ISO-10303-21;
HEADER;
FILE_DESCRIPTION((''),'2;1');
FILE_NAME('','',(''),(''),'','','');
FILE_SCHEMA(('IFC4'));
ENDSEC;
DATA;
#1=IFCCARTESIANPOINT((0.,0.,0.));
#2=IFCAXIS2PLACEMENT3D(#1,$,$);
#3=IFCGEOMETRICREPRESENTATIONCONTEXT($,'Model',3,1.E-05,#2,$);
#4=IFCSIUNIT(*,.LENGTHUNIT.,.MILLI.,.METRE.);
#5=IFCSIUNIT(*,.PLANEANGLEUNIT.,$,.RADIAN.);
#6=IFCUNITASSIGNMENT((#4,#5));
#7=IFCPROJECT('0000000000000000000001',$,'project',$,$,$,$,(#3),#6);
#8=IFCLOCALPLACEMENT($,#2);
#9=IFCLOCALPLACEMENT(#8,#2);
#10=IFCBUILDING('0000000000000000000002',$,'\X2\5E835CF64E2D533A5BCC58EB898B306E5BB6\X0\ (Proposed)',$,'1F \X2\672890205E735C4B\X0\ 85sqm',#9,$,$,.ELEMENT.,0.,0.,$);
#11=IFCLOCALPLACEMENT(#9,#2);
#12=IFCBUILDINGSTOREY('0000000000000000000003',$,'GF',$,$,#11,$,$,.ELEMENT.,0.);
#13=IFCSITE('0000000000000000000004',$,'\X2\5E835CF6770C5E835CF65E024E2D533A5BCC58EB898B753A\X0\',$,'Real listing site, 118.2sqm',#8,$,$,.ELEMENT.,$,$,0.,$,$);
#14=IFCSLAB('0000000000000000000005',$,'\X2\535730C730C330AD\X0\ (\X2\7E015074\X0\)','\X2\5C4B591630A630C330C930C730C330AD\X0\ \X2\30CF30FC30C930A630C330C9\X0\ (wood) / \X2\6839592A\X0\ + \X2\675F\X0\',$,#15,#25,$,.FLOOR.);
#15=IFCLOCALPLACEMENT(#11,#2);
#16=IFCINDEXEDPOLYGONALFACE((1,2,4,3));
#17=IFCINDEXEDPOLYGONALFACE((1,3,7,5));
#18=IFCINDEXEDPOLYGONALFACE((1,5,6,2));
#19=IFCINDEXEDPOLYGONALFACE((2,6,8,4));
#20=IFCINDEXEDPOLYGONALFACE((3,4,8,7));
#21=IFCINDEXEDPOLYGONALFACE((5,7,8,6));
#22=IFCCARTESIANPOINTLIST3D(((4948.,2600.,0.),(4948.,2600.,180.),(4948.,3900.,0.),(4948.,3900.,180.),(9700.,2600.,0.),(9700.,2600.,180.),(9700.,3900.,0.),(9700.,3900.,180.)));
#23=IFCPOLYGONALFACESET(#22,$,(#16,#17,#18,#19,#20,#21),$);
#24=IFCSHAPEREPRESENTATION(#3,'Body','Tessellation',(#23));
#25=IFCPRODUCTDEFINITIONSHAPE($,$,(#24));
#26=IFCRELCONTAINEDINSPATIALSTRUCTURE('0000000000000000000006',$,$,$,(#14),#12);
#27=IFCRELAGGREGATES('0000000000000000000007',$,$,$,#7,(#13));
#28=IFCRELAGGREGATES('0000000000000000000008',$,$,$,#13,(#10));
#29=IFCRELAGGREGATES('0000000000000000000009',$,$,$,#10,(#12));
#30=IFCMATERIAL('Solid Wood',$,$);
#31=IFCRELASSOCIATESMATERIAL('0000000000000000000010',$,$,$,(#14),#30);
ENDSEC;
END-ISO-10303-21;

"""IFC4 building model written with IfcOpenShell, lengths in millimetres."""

from ifc_helpers import new_model, si_unit, frame, frame_2d, origin, place, context, project, spatial, rectangle, extrude, material, element, save


model = new_model("IFC4")

# Units and contexts
model_context = context("Model", 3, precision=1e-05, world=origin())
ifc_project = project(units=[si_unit("LENGTHUNIT", "METRE", prefix="MILLI"), si_unit("PLANEANGLEUNIT", "RADIAN")], contexts=[model_context])

# Site, building, storey
site_placement = place(None, origin())
site = spatial("IfcSite", under=ifc_project, at=site_placement, Name="広島県広島市中区富士見町", ObjectType="Real listing site, 118.2sqm", CompositionType="ELEMENT", RefElevation=0.0)
building_placement = place(site_placement, origin())
building = spatial("IfcBuilding", under=site, at=building_placement, Name="広島中区富士見の家 (Proposed)", ObjectType="1F 木造平屋 85sqm", CompositionType="ELEMENT", ElevationOfRefHeight=0.0, ElevationOfTerrain=0.0)
storey_placement = place(building_placement, origin())
storey = spatial("IfcBuildingStorey", under=building, at=storey_placement, Name="GF", CompositionType="ELEMENT", Elevation=0.0)

# Slab
ifc_material_1 = material(Name="Solid Wood")
slab_1_placement = place(storey_placement, frame((2474.0, 1300.0, 0.0)))
element("IfcSlab", 1, at=slab_1_placement, inside=storey, material=ifc_material_1, Name="南デッキ (縁側)", Description="屋外ウッドデッキ ハードウッド (wood) / 根太 + 束", PredefinedType="FLOOR", context=model_context, shape_type="SweptSolid", body=[
    extrude(rectangle(XDim=4752.0, YDim=1300.0, at=frame_2d((2376.0, 650.0))), frame((2474.0, 1300.0, 0.0)), (0.0, 0.0, 1.0), 180.0),
])

save(model, "model.ifc")
